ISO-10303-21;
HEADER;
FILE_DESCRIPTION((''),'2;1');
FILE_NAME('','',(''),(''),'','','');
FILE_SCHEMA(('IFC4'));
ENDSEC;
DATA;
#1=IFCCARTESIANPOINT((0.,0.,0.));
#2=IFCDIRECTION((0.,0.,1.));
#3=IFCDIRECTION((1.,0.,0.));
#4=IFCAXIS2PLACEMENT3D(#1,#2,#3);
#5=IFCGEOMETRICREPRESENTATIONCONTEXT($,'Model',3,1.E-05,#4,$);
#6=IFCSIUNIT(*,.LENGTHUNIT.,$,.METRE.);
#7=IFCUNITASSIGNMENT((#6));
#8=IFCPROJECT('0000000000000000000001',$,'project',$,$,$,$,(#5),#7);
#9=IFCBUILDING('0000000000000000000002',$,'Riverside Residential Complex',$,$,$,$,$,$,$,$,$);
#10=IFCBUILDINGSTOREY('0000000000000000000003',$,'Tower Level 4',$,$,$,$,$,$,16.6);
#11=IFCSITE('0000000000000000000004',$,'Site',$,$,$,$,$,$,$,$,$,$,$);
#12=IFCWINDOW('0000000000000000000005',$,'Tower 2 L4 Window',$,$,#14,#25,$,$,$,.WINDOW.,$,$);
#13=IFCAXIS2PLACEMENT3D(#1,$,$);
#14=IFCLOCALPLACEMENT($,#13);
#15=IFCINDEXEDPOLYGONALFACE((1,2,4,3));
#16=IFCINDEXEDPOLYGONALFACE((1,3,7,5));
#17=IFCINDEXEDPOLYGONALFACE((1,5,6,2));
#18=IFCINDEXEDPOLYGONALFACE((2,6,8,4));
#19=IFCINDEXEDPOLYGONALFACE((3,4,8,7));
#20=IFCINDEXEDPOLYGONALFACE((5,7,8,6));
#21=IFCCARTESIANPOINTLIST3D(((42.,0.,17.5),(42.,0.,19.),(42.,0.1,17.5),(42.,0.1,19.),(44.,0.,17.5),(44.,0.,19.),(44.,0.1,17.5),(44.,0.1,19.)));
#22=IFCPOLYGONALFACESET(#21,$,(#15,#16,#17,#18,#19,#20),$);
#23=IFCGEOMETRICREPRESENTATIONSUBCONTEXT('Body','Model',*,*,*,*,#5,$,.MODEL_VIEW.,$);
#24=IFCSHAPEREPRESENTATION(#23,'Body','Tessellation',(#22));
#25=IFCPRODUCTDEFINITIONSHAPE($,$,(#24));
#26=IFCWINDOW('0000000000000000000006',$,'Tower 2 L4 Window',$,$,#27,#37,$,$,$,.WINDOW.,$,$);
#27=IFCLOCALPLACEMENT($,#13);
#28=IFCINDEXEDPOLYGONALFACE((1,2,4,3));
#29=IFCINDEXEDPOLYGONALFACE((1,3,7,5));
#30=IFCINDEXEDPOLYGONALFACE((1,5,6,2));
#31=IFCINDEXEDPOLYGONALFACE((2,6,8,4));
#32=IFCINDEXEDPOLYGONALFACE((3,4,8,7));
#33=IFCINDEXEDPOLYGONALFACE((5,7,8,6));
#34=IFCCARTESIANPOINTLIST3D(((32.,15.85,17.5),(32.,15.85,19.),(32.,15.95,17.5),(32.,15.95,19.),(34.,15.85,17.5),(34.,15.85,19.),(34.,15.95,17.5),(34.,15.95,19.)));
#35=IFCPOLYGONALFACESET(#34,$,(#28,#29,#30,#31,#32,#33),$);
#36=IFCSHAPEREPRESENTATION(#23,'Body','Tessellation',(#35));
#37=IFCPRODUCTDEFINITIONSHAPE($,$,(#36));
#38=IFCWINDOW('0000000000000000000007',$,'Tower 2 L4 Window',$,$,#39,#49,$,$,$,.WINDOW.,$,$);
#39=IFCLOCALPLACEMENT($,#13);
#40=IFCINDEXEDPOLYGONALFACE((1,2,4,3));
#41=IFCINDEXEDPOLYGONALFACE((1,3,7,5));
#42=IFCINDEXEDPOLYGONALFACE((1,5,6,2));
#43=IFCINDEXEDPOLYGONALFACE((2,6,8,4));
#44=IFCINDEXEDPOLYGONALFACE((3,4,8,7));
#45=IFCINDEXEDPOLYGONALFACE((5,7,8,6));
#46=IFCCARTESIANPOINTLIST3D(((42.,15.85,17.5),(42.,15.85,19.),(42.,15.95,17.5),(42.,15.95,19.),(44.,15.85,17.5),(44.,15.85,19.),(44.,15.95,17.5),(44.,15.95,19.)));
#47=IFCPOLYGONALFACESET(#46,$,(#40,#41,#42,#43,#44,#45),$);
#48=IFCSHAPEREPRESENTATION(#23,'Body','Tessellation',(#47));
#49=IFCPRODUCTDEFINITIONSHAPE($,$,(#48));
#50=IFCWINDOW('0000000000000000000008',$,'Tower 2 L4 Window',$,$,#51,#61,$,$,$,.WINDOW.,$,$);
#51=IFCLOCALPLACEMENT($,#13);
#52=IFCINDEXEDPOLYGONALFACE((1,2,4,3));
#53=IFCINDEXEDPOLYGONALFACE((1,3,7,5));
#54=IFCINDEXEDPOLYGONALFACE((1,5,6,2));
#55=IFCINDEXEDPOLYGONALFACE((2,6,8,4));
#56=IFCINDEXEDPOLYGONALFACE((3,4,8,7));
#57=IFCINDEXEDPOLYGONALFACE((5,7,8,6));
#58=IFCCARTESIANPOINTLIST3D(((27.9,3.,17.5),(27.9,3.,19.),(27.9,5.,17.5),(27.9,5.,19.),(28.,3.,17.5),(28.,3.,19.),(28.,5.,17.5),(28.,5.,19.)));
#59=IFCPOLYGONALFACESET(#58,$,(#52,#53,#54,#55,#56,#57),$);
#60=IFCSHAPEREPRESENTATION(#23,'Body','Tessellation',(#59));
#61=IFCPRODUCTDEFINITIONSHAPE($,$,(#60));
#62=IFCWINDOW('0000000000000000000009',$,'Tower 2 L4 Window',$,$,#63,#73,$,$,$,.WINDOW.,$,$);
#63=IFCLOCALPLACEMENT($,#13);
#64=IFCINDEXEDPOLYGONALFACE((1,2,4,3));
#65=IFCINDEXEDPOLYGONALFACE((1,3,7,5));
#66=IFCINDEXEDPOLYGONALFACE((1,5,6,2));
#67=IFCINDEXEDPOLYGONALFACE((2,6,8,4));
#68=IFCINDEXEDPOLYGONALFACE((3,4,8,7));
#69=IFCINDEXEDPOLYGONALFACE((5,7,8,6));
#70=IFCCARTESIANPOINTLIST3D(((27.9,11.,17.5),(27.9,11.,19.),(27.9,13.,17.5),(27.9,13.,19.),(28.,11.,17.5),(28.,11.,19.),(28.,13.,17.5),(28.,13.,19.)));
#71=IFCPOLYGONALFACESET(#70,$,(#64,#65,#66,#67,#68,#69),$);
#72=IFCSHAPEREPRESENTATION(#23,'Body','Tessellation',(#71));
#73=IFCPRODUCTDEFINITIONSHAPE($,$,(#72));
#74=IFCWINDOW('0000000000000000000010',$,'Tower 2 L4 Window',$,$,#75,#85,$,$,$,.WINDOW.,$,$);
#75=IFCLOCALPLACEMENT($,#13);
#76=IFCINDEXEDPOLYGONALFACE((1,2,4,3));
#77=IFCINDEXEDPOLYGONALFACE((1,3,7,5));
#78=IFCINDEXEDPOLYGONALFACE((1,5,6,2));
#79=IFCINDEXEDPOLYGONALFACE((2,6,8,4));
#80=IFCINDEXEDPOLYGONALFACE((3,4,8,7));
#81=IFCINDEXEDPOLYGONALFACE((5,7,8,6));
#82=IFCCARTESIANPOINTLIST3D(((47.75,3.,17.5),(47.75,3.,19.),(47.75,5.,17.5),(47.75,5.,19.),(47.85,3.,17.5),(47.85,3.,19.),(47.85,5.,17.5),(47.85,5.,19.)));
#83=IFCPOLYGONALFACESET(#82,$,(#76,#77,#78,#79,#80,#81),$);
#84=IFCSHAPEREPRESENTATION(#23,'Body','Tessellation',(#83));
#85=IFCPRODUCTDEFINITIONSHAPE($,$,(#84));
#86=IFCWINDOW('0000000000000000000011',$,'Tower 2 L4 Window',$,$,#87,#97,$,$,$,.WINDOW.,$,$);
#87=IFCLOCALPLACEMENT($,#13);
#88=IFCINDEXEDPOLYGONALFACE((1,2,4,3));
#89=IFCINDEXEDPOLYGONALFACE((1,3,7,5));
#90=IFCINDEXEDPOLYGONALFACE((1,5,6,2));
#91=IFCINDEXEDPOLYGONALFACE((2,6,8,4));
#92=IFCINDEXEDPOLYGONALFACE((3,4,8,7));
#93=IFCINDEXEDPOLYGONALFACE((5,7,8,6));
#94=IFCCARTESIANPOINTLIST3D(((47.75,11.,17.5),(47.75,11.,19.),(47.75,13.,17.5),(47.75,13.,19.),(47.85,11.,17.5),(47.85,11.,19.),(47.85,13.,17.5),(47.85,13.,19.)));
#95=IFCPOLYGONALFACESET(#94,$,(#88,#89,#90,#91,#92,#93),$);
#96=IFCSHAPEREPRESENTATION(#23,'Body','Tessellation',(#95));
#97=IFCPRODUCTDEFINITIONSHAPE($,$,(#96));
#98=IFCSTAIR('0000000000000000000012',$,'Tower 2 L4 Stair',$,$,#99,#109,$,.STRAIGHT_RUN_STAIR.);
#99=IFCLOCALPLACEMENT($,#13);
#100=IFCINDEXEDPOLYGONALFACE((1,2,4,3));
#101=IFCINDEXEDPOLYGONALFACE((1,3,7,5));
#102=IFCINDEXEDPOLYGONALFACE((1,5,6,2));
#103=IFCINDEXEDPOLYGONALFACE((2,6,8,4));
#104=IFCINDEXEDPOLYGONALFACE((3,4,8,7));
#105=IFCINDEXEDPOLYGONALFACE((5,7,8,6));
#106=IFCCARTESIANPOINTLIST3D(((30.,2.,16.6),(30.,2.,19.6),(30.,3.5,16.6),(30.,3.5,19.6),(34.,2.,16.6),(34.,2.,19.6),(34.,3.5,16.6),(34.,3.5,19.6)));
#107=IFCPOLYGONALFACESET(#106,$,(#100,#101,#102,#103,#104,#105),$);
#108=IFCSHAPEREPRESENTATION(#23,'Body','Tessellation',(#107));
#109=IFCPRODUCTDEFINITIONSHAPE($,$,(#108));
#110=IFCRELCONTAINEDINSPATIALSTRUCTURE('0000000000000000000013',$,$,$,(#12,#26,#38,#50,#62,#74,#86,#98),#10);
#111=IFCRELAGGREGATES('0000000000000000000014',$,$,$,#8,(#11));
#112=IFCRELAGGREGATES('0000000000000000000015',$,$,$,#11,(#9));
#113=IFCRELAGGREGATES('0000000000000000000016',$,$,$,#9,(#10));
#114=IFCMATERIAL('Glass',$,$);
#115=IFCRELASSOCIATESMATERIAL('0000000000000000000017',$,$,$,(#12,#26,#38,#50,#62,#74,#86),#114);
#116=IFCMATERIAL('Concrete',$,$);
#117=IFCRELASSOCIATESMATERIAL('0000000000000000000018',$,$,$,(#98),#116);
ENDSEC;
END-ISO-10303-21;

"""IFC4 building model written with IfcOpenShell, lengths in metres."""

from ifc_helpers import new_model, si_unit, frame, origin_with_axes, place, context, subcontext, project, spatial, line, indexed_curve, outline, extrude, material, element, save


model = new_model("IFC4")

# Units and contexts
model_context = context("Model", 3, precision=1e-05, world=origin_with_axes())
body_context = subcontext(model_context, "Body", "Model", "MODEL_VIEW")
ifc_project = project(units=[si_unit("LENGTHUNIT", "METRE")], contexts=[model_context])

# Site, building, storey
site = spatial("IfcSite", under=ifc_project, Name="Site")
building = spatial("IfcBuilding", under=site, Name="Riverside Residential Complex")
storey = spatial("IfcBuildingStorey", under=building, Name="Tower Level 4", Elevation=16.6)

# Shared definitions
ifc_material_1 = material(Name="Concrete")

# Windows
ifc_material_2 = material(Name="Glass")
for number, where, z_axis, x_axis, name in (
    (1, (42.0, 0.0, 17.5), (0.0, 0.0, 1.0), (1.0, 0.0, 0.0), "Tower 2 L4 Window"),
    (2, (32.0, 15.85, 17.5), (0.0, 0.0, 1.0), (1.0, 0.0, 0.0), "Tower 2 L4 Window"),
    (3, (42.0, 15.85, 17.5), (0.0, 0.0, 1.0), (1.0, 0.0, 0.0), "Tower 2 L4 Window"),
    (4, (28.0, 3.0, 17.5), (0.0, 0.0, 1.0), (0.0, 1.0, 0.0), "Tower 2 L4 Window"),
    (5, (28.0, 11.0, 17.5), (0.0, 0.0, 1.0), (0.0, 1.0, 0.0), "Tower 2 L4 Window"),
    (6, (47.85, 3.0, 17.5), (0.0, 0.0, 1.0), (0.0, 1.0, 0.0), "Tower 2 L4 Window"),
    (7, (47.85, 11.0, 17.5), (0.0, 0.0, 1.0), (0.0, 1.0, 0.0), "Tower 2 L4 Window"),
):
    element("IfcWindow", number, at=place(None, frame(where, z_axis=z_axis, x_axis=x_axis)), inside=storey, material=ifc_material_2, Name=name, PredefinedType="WINDOW", context=body_context, shape_type="SweptSolid", body=[
        extrude(outline(indexed_curve([(0.0, 0.0), (2.0, 0.0), (2.0, 0.1), (0.0, 0.1)], segments=[line(1, 2, 3, 4, 1)])), origin_with_axes(), (0.0, 0.0, 1.0), 1.5),
    ])

# Stair
stair_placement = place(None, frame((30.0, 2.0, 16.6), z_axis=(0.0, 0.0, 1.0), x_axis=(1.0, 0.0, 0.0)))
element("IfcStair", 8, at=stair_placement, inside=storey, material=ifc_material_1, Name="Tower 2 L4 Stair", PredefinedType="STRAIGHT_RUN_STAIR", context=body_context, shape_type="SweptSolid", body=[
    extrude(outline(indexed_curve([(0.0, 0.0), (4.0, 0.0), (4.0, 1.5), (0.0, 1.5)], segments=[line(1, 2, 3, 4, 1)])), origin_with_axes(), (0.0, 0.0, 1.0), 3.0),
])

save(model, "model.ifc")
